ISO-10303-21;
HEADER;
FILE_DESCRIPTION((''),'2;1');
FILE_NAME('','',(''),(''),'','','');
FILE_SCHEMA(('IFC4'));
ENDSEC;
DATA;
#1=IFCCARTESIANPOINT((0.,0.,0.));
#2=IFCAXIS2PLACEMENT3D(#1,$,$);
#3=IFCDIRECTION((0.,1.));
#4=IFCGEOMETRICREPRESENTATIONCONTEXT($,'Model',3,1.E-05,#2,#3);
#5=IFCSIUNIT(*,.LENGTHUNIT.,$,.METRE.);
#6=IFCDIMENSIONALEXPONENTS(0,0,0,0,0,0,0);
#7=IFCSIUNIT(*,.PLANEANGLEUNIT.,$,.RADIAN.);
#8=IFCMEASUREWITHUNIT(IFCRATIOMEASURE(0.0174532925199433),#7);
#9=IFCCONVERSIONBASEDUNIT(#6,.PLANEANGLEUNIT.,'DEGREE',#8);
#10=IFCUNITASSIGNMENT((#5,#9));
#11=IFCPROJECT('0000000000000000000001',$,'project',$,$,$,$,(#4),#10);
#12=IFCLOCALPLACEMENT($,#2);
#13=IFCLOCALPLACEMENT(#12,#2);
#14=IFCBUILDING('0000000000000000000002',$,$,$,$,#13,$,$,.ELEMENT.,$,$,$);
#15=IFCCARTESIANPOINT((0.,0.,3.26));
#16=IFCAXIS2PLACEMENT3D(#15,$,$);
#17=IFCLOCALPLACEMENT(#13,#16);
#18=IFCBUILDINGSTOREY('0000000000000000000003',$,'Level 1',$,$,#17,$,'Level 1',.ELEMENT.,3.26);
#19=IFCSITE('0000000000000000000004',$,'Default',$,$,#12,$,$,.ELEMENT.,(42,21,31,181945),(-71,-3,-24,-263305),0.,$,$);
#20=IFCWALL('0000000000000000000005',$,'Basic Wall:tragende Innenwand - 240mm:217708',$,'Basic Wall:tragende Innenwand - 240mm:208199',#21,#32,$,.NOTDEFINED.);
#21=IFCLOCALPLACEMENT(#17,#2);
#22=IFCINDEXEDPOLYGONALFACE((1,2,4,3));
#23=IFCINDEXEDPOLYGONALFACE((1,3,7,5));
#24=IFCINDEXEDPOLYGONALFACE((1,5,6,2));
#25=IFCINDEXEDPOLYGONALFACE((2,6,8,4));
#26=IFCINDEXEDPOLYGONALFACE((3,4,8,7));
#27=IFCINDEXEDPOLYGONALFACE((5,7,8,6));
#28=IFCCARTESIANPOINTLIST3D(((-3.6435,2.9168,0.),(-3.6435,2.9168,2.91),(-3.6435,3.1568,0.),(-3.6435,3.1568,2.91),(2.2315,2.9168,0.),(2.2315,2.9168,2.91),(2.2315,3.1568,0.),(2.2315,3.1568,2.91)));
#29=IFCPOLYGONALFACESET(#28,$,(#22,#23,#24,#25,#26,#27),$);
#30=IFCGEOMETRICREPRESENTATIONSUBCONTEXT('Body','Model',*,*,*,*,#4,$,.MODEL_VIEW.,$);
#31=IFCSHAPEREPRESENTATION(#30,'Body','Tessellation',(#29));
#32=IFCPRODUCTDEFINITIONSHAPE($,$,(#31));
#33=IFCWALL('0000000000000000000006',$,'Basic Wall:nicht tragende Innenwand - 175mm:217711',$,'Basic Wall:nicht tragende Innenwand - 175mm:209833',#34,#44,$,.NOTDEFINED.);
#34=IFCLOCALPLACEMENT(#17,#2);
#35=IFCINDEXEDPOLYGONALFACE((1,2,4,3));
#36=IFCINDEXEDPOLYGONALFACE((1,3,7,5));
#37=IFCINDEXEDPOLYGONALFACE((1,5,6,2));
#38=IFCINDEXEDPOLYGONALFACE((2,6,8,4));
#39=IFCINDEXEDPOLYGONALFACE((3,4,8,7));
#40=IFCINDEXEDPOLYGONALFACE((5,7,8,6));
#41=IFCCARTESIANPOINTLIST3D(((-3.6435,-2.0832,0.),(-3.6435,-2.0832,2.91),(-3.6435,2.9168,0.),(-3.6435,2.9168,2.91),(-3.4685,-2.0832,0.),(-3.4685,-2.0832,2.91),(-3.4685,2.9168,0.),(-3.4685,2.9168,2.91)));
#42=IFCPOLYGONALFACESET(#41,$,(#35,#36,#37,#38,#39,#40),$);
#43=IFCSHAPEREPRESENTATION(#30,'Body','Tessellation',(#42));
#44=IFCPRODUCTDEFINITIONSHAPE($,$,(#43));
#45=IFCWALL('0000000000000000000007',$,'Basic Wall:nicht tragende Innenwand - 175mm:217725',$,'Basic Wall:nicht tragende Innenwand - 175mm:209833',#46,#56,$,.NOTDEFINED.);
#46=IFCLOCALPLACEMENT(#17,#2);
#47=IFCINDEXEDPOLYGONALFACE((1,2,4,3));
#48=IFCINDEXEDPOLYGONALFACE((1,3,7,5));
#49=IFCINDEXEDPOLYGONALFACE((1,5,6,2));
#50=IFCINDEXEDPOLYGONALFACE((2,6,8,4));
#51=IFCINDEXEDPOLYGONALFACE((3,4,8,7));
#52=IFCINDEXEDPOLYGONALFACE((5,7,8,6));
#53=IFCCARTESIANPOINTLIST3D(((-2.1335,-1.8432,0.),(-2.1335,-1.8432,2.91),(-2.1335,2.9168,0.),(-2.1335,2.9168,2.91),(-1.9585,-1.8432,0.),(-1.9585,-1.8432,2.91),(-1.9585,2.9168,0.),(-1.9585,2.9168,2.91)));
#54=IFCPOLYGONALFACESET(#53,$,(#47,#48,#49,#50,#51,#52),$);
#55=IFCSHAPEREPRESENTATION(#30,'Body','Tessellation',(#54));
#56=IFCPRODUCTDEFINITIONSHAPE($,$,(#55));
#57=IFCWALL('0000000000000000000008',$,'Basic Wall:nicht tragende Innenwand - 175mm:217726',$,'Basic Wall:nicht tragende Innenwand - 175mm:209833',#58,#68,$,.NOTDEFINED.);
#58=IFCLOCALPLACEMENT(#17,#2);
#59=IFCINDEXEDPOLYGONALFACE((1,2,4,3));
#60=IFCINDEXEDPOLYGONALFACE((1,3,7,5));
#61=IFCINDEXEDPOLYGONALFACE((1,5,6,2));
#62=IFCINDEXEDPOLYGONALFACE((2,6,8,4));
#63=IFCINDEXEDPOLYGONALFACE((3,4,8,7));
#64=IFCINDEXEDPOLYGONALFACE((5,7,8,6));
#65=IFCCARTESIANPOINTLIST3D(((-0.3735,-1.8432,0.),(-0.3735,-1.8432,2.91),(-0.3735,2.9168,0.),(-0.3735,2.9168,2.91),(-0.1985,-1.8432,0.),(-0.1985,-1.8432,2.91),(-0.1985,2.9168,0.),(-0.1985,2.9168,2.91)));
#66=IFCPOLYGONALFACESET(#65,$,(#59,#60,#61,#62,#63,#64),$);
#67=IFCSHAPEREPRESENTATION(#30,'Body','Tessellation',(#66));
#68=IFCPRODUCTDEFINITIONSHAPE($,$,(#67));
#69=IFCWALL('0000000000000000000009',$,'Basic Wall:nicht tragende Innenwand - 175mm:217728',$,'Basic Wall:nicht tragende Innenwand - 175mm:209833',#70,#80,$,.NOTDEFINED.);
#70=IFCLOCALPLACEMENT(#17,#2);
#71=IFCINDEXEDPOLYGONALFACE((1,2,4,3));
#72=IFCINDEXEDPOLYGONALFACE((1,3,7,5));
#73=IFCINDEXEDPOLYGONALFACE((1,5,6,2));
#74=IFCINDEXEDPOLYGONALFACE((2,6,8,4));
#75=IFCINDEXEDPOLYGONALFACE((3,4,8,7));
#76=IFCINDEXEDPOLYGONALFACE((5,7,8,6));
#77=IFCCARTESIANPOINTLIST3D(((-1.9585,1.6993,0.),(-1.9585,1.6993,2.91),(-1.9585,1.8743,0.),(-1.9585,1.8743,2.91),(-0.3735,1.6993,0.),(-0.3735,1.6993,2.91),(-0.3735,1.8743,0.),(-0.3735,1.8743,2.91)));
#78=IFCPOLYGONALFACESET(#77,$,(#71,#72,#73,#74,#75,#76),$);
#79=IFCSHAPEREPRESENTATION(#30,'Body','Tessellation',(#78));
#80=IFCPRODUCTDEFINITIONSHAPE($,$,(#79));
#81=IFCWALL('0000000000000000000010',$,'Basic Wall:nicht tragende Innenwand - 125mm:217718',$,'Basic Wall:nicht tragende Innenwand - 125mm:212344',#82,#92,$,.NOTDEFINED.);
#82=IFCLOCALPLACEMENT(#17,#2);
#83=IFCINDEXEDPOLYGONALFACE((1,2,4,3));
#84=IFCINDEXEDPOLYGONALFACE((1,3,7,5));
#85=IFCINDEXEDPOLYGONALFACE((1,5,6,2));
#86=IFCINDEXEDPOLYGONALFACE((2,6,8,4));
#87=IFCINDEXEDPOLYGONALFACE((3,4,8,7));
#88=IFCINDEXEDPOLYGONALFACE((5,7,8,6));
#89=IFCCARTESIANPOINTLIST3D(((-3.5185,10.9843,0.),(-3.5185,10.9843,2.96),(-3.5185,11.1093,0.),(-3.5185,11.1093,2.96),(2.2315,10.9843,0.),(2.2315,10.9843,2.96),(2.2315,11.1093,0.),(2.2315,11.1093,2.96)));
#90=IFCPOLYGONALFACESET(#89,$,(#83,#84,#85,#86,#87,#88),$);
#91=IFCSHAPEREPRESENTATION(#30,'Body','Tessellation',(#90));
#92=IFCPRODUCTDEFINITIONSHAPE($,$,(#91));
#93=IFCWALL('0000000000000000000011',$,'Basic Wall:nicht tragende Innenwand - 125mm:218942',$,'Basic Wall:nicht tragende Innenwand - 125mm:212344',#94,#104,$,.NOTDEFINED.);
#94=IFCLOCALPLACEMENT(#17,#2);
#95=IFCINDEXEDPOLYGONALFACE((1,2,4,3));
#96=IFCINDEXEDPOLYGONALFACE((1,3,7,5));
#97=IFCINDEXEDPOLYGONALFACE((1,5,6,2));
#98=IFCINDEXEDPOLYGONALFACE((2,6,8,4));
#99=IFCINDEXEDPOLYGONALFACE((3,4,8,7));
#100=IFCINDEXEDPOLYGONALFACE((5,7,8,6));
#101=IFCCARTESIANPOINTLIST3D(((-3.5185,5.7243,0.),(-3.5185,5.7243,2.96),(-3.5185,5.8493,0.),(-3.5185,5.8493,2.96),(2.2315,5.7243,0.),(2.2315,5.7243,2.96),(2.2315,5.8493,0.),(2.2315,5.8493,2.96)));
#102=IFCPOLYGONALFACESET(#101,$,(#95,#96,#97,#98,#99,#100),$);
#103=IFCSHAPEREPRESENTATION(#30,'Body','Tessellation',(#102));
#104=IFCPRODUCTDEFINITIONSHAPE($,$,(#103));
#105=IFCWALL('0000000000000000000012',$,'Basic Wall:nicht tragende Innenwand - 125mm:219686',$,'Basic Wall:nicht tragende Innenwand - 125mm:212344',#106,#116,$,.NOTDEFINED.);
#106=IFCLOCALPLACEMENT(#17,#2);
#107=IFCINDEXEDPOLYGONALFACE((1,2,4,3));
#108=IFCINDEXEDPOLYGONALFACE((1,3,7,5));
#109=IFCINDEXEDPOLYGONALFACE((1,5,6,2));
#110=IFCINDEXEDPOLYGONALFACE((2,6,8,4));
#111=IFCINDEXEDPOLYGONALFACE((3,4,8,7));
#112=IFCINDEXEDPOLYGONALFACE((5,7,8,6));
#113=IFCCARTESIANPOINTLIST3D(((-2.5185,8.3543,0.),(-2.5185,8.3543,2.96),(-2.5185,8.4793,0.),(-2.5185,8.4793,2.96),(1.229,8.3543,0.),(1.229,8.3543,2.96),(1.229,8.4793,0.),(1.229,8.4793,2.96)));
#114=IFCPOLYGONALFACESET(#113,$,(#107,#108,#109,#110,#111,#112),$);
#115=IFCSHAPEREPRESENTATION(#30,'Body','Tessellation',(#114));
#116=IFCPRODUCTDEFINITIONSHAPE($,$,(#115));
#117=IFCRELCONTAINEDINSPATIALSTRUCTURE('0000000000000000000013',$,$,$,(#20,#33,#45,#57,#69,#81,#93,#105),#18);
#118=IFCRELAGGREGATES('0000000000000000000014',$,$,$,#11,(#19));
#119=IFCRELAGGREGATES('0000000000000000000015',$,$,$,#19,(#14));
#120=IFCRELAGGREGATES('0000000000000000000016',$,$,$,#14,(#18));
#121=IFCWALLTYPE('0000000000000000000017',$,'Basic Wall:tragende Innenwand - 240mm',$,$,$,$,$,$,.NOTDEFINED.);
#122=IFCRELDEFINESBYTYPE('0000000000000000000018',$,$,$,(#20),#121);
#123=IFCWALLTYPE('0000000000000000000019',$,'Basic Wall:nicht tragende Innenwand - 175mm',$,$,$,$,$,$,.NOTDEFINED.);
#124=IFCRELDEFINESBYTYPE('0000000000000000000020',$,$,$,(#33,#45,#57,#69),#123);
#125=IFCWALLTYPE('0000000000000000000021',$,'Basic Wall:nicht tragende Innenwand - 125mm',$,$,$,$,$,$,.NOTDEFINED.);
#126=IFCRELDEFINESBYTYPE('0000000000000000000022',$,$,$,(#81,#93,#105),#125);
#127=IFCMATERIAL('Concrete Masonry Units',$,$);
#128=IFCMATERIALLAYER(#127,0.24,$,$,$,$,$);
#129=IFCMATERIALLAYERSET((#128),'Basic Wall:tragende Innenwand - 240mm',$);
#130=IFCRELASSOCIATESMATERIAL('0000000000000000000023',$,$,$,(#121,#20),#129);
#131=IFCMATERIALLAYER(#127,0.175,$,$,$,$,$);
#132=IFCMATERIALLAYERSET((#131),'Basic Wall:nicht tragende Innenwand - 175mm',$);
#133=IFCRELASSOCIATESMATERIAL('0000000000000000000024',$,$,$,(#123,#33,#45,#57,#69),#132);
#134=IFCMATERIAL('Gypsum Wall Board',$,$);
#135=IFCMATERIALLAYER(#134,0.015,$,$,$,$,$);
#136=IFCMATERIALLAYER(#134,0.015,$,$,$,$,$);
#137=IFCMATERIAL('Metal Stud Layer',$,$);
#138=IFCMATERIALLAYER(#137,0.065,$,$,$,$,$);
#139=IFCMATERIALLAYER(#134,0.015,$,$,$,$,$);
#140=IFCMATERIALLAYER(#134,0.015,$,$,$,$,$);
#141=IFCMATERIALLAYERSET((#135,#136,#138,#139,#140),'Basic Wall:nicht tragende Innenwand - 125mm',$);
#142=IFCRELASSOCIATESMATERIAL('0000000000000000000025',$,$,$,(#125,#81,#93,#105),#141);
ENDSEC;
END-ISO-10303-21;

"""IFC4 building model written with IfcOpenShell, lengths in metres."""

from ifc_helpers import new_model, entity, si_unit, converted_unit, direction, frame, frame_2d, origin, place, context, subcontext, project, spatial, rectangle, extrude, material, layer, layer_set, layer_usage, type_object, element, save


model = new_model("IFC4")

# Units and contexts
model_context = context("Model", 3, precision=1e-05, world=origin(), true_north=direction((0.0, 1.0)))
body_context = subcontext(model_context, "Body", "Model", "MODEL_VIEW")
ifc_project = project(units=[si_unit("LENGTHUNIT", "METRE"), converted_unit("PLANEANGLEUNIT", "DEGREE", entity("IfcRatioMeasure", 0.0174532925199433), si_unit("PLANEANGLEUNIT", "RADIAN"), dimensions=[0, 0, 0, 0, 0, 0, 0])], contexts=[model_context])

# Site, building, storey
site_placement = place(None, origin())
site = spatial("IfcSite", under=ifc_project, at=site_placement, Name="Default", CompositionType="ELEMENT", RefLatitude=(42, 21, 31, 181945), RefLongitude=(-71, -3, -24, -263305), RefElevation=0.0)
building_placement = place(site_placement, origin())
building = spatial("IfcBuilding", under=site, at=building_placement, CompositionType="ELEMENT")
storey_placement = place(building_placement, frame((0.0, 0.0, 3.26)))
storey = spatial("IfcBuildingStorey", under=building, at=storey_placement, Name="Level 1", LongName="Level 1", CompositionType="ELEMENT", Elevation=3.26)

# Walls
ifc_material_1 = material(Name="Concrete Masonry Units")
ifc_layer_1 = layer(ifc_material_1, 0.24)
ifc_layer_set_1 = layer_set([ifc_layer_1], Name="Basic Wall:tragende Innenwand - 240mm")
ifc_layer_usage_1 = layer_usage(ifc_layer_set_1, "AXIS2", "NEGATIVE", 0.12)
wall_type_1 = type_object("IfcWallType", Name="Basic Wall:tragende Innenwand - 240mm", PredefinedType="NOTDEFINED", material=ifc_layer_set_1)
wall_1_placement = place(storey_placement, frame((2.2315, 3.0368, 0.0), z_axis=(0.0, 0.0, 1.0), x_axis=(-1.0, 0.0, 0.0)))
element("IfcWall", 1, at=wall_1_placement, inside=storey, type_object=wall_type_1, material=ifc_layer_usage_1, Name="Basic Wall:tragende Innenwand - 240mm:217708", ObjectType="Basic Wall:tragende Innenwand - 240mm:208199", PredefinedType="NOTDEFINED", context=body_context, shape_type="SweptSolid", body=[
    extrude(rectangle(XDim=5.875, YDim=0.24, at=frame_2d((2.9375, 0.0), x_axis=(-1.0, 0.0))), origin(), (0.0, 0.0, 1.0), 2.91),
])
ifc_layer_2 = layer(ifc_material_1, 0.175)
ifc_layer_set_2 = layer_set([ifc_layer_2], Name="Basic Wall:nicht tragende Innenwand - 175mm")
ifc_layer_usage_2 = layer_usage(ifc_layer_set_2, "AXIS2", "NEGATIVE", 0.0875)
wall_type_2 = type_object("IfcWallType", Name="Basic Wall:nicht tragende Innenwand - 175mm", PredefinedType="NOTDEFINED", material=ifc_layer_set_2)
wall_2_placement = place(storey_placement, frame((-3.556, 2.9168, 0.0), z_axis=(0.0, 0.0, 1.0), x_axis=(0.0, -1.0, 0.0)))
element("IfcWall", 2, at=wall_2_placement, inside=storey, type_object=wall_type_2, material=ifc_layer_usage_2, Name="Basic Wall:nicht tragende Innenwand - 175mm:217711", ObjectType="Basic Wall:nicht tragende Innenwand - 175mm:209833", PredefinedType="NOTDEFINED", context=body_context, shape_type="SweptSolid", body=[
    extrude(rectangle(XDim=5.0, YDim=0.175, at=frame_2d((2.5, 0.0), x_axis=(-1.0, 0.0))), origin(), (0.0, 0.0, 1.0), 2.91),
])
ifc_layer_usage_3 = layer_usage(ifc_layer_set_2, "AXIS2", "NEGATIVE", 0.0875)
wall_3_placement = place(storey_placement, frame((-2.046, 2.9168, 0.0), z_axis=(0.0, 0.0, 1.0), x_axis=(0.0, -1.0, 0.0)))
element("IfcWall", 3, at=wall_3_placement, inside=storey, type_object=wall_type_2, material=ifc_layer_usage_3, Name="Basic Wall:nicht tragende Innenwand - 175mm:217725", ObjectType="Basic Wall:nicht tragende Innenwand - 175mm:209833", PredefinedType="NOTDEFINED", context=body_context, shape_type="SweptSolid", body=[
    extrude(rectangle(XDim=4.76, YDim=0.175, at=frame_2d((2.38, 0.0), x_axis=(-1.0, 0.0))), origin(), (0.0, 0.0, 1.0), 2.91),
])
ifc_layer_usage_4 = layer_usage(ifc_layer_set_2, "AXIS2", "NEGATIVE", 0.0875)
wall_4_placement = place(storey_placement, frame((-0.286, 2.9168, 0.0), z_axis=(0.0, 0.0, 1.0), x_axis=(0.0, -1.0, 0.0)))
element("IfcWall", 4, at=wall_4_placement, inside=storey, type_object=wall_type_2, material=ifc_layer_usage_4, Name="Basic Wall:nicht tragende Innenwand - 175mm:217726", ObjectType="Basic Wall:nicht tragende Innenwand - 175mm:209833", PredefinedType="NOTDEFINED", context=body_context, shape_type="SweptSolid", body=[
    extrude(rectangle(XDim=4.76, YDim=0.175, at=frame_2d((2.38, 0.0), x_axis=(-1.0, 0.0))), origin(), (0.0, 0.0, 1.0), 2.91),
])
ifc_layer_usage_5 = layer_usage(ifc_layer_set_2, "AXIS2", "POSITIVE", -0.0875)
wall_5_placement = place(storey_placement, frame((-1.9585, 1.7868, 0.0)))
element("IfcWall", 5, at=wall_5_placement, inside=storey, type_object=wall_type_2, material=ifc_layer_usage_5, Name="Basic Wall:nicht tragende Innenwand - 175mm:217728", ObjectType="Basic Wall:nicht tragende Innenwand - 175mm:209833", PredefinedType="NOTDEFINED", context=body_context, shape_type="SweptSolid", body=[
    extrude(rectangle(XDim=1.585, YDim=0.175, at=frame_2d((0.7925, 0.0), x_axis=(-1.0, 0.0))), origin(), (0.0, 0.0, 1.0), 2.91),
])
ifc_material_2 = material(Name="Gypsum Wall Board")
ifc_layer_3 = layer(ifc_material_2, 0.015)
ifc_layer_4 = layer(ifc_material_2, 0.015)
ifc_material_3 = material(Name="Metal Stud Layer")
ifc_layer_5 = layer(ifc_material_3, 0.065)
ifc_layer_6 = layer(ifc_material_2, 0.015)
ifc_layer_7 = layer(ifc_material_2, 0.015)
ifc_layer_set_3 = layer_set([ifc_layer_3, ifc_layer_4, ifc_layer_5, ifc_layer_6, ifc_layer_7], Name="Basic Wall:nicht tragende Innenwand - 125mm")
ifc_layer_usage_6 = layer_usage(ifc_layer_set_3, "AXIS2", "NEGATIVE", 0.0625)
wall_type_3 = type_object("IfcWallType", Name="Basic Wall:nicht tragende Innenwand - 125mm", PredefinedType="NOTDEFINED", material=ifc_layer_set_3)
wall_6_placement = place(storey_placement, frame((2.2315, 11.0468, 0.0), z_axis=(0.0, 0.0, 1.0), x_axis=(-1.0, 0.0, 0.0)))
element("IfcWall", 6, at=wall_6_placement, inside=storey, type_object=wall_type_3, material=ifc_layer_usage_6, Name="Basic Wall:nicht tragende Innenwand - 125mm:217718", ObjectType="Basic Wall:nicht tragende Innenwand - 125mm:212344", PredefinedType="NOTDEFINED", context=body_context, shape_type="SweptSolid", body=[
    extrude(rectangle(XDim=5.75, YDim=0.125, at=frame_2d((2.875, 0.0), x_axis=(-1.0, 0.0))), origin(), (0.0, 0.0, 1.0), 2.96),
])
ifc_layer_usage_7 = layer_usage(ifc_layer_set_3, "AXIS2", "POSITIVE", -0.0625)
wall_7_placement = place(storey_placement, frame((-3.5185, 5.7868, 0.0)))
element("IfcWall", 7, at=wall_7_placement, inside=storey, type_object=wall_type_3, material=ifc_layer_usage_7, Name="Basic Wall:nicht tragende Innenwand - 125mm:218942", ObjectType="Basic Wall:nicht tragende Innenwand - 125mm:212344", PredefinedType="NOTDEFINED", context=body_context, shape_type="SweptSolid", body=[
    extrude(rectangle(XDim=5.75, YDim=0.125, at=frame_2d((2.875, 0.0), x_axis=(-1.0, 0.0))), origin(), (0.0, 0.0, 1.0), 2.96),
])
ifc_layer_usage_8 = layer_usage(ifc_layer_set_3, "AXIS2", "POSITIVE", -0.0625)
wall_8_placement = place(storey_placement, frame((-2.5185, 8.4168, 0.0)))
element("IfcWall", 8, at=wall_8_placement, inside=storey, type_object=wall_type_3, material=ifc_layer_usage_8, Name="Basic Wall:nicht tragende Innenwand - 125mm:219686", ObjectType="Basic Wall:nicht tragende Innenwand - 125mm:212344", PredefinedType="NOTDEFINED", context=body_context, shape_type="SweptSolid", body=[
    extrude(rectangle(XDim=3.7475, YDim=0.125, at=frame_2d((1.8738, 0.0), x_axis=(-1.0, 0.0))), origin(), (0.0, 0.0, 1.0), 2.96),
])

save(model, "model.ifc")
